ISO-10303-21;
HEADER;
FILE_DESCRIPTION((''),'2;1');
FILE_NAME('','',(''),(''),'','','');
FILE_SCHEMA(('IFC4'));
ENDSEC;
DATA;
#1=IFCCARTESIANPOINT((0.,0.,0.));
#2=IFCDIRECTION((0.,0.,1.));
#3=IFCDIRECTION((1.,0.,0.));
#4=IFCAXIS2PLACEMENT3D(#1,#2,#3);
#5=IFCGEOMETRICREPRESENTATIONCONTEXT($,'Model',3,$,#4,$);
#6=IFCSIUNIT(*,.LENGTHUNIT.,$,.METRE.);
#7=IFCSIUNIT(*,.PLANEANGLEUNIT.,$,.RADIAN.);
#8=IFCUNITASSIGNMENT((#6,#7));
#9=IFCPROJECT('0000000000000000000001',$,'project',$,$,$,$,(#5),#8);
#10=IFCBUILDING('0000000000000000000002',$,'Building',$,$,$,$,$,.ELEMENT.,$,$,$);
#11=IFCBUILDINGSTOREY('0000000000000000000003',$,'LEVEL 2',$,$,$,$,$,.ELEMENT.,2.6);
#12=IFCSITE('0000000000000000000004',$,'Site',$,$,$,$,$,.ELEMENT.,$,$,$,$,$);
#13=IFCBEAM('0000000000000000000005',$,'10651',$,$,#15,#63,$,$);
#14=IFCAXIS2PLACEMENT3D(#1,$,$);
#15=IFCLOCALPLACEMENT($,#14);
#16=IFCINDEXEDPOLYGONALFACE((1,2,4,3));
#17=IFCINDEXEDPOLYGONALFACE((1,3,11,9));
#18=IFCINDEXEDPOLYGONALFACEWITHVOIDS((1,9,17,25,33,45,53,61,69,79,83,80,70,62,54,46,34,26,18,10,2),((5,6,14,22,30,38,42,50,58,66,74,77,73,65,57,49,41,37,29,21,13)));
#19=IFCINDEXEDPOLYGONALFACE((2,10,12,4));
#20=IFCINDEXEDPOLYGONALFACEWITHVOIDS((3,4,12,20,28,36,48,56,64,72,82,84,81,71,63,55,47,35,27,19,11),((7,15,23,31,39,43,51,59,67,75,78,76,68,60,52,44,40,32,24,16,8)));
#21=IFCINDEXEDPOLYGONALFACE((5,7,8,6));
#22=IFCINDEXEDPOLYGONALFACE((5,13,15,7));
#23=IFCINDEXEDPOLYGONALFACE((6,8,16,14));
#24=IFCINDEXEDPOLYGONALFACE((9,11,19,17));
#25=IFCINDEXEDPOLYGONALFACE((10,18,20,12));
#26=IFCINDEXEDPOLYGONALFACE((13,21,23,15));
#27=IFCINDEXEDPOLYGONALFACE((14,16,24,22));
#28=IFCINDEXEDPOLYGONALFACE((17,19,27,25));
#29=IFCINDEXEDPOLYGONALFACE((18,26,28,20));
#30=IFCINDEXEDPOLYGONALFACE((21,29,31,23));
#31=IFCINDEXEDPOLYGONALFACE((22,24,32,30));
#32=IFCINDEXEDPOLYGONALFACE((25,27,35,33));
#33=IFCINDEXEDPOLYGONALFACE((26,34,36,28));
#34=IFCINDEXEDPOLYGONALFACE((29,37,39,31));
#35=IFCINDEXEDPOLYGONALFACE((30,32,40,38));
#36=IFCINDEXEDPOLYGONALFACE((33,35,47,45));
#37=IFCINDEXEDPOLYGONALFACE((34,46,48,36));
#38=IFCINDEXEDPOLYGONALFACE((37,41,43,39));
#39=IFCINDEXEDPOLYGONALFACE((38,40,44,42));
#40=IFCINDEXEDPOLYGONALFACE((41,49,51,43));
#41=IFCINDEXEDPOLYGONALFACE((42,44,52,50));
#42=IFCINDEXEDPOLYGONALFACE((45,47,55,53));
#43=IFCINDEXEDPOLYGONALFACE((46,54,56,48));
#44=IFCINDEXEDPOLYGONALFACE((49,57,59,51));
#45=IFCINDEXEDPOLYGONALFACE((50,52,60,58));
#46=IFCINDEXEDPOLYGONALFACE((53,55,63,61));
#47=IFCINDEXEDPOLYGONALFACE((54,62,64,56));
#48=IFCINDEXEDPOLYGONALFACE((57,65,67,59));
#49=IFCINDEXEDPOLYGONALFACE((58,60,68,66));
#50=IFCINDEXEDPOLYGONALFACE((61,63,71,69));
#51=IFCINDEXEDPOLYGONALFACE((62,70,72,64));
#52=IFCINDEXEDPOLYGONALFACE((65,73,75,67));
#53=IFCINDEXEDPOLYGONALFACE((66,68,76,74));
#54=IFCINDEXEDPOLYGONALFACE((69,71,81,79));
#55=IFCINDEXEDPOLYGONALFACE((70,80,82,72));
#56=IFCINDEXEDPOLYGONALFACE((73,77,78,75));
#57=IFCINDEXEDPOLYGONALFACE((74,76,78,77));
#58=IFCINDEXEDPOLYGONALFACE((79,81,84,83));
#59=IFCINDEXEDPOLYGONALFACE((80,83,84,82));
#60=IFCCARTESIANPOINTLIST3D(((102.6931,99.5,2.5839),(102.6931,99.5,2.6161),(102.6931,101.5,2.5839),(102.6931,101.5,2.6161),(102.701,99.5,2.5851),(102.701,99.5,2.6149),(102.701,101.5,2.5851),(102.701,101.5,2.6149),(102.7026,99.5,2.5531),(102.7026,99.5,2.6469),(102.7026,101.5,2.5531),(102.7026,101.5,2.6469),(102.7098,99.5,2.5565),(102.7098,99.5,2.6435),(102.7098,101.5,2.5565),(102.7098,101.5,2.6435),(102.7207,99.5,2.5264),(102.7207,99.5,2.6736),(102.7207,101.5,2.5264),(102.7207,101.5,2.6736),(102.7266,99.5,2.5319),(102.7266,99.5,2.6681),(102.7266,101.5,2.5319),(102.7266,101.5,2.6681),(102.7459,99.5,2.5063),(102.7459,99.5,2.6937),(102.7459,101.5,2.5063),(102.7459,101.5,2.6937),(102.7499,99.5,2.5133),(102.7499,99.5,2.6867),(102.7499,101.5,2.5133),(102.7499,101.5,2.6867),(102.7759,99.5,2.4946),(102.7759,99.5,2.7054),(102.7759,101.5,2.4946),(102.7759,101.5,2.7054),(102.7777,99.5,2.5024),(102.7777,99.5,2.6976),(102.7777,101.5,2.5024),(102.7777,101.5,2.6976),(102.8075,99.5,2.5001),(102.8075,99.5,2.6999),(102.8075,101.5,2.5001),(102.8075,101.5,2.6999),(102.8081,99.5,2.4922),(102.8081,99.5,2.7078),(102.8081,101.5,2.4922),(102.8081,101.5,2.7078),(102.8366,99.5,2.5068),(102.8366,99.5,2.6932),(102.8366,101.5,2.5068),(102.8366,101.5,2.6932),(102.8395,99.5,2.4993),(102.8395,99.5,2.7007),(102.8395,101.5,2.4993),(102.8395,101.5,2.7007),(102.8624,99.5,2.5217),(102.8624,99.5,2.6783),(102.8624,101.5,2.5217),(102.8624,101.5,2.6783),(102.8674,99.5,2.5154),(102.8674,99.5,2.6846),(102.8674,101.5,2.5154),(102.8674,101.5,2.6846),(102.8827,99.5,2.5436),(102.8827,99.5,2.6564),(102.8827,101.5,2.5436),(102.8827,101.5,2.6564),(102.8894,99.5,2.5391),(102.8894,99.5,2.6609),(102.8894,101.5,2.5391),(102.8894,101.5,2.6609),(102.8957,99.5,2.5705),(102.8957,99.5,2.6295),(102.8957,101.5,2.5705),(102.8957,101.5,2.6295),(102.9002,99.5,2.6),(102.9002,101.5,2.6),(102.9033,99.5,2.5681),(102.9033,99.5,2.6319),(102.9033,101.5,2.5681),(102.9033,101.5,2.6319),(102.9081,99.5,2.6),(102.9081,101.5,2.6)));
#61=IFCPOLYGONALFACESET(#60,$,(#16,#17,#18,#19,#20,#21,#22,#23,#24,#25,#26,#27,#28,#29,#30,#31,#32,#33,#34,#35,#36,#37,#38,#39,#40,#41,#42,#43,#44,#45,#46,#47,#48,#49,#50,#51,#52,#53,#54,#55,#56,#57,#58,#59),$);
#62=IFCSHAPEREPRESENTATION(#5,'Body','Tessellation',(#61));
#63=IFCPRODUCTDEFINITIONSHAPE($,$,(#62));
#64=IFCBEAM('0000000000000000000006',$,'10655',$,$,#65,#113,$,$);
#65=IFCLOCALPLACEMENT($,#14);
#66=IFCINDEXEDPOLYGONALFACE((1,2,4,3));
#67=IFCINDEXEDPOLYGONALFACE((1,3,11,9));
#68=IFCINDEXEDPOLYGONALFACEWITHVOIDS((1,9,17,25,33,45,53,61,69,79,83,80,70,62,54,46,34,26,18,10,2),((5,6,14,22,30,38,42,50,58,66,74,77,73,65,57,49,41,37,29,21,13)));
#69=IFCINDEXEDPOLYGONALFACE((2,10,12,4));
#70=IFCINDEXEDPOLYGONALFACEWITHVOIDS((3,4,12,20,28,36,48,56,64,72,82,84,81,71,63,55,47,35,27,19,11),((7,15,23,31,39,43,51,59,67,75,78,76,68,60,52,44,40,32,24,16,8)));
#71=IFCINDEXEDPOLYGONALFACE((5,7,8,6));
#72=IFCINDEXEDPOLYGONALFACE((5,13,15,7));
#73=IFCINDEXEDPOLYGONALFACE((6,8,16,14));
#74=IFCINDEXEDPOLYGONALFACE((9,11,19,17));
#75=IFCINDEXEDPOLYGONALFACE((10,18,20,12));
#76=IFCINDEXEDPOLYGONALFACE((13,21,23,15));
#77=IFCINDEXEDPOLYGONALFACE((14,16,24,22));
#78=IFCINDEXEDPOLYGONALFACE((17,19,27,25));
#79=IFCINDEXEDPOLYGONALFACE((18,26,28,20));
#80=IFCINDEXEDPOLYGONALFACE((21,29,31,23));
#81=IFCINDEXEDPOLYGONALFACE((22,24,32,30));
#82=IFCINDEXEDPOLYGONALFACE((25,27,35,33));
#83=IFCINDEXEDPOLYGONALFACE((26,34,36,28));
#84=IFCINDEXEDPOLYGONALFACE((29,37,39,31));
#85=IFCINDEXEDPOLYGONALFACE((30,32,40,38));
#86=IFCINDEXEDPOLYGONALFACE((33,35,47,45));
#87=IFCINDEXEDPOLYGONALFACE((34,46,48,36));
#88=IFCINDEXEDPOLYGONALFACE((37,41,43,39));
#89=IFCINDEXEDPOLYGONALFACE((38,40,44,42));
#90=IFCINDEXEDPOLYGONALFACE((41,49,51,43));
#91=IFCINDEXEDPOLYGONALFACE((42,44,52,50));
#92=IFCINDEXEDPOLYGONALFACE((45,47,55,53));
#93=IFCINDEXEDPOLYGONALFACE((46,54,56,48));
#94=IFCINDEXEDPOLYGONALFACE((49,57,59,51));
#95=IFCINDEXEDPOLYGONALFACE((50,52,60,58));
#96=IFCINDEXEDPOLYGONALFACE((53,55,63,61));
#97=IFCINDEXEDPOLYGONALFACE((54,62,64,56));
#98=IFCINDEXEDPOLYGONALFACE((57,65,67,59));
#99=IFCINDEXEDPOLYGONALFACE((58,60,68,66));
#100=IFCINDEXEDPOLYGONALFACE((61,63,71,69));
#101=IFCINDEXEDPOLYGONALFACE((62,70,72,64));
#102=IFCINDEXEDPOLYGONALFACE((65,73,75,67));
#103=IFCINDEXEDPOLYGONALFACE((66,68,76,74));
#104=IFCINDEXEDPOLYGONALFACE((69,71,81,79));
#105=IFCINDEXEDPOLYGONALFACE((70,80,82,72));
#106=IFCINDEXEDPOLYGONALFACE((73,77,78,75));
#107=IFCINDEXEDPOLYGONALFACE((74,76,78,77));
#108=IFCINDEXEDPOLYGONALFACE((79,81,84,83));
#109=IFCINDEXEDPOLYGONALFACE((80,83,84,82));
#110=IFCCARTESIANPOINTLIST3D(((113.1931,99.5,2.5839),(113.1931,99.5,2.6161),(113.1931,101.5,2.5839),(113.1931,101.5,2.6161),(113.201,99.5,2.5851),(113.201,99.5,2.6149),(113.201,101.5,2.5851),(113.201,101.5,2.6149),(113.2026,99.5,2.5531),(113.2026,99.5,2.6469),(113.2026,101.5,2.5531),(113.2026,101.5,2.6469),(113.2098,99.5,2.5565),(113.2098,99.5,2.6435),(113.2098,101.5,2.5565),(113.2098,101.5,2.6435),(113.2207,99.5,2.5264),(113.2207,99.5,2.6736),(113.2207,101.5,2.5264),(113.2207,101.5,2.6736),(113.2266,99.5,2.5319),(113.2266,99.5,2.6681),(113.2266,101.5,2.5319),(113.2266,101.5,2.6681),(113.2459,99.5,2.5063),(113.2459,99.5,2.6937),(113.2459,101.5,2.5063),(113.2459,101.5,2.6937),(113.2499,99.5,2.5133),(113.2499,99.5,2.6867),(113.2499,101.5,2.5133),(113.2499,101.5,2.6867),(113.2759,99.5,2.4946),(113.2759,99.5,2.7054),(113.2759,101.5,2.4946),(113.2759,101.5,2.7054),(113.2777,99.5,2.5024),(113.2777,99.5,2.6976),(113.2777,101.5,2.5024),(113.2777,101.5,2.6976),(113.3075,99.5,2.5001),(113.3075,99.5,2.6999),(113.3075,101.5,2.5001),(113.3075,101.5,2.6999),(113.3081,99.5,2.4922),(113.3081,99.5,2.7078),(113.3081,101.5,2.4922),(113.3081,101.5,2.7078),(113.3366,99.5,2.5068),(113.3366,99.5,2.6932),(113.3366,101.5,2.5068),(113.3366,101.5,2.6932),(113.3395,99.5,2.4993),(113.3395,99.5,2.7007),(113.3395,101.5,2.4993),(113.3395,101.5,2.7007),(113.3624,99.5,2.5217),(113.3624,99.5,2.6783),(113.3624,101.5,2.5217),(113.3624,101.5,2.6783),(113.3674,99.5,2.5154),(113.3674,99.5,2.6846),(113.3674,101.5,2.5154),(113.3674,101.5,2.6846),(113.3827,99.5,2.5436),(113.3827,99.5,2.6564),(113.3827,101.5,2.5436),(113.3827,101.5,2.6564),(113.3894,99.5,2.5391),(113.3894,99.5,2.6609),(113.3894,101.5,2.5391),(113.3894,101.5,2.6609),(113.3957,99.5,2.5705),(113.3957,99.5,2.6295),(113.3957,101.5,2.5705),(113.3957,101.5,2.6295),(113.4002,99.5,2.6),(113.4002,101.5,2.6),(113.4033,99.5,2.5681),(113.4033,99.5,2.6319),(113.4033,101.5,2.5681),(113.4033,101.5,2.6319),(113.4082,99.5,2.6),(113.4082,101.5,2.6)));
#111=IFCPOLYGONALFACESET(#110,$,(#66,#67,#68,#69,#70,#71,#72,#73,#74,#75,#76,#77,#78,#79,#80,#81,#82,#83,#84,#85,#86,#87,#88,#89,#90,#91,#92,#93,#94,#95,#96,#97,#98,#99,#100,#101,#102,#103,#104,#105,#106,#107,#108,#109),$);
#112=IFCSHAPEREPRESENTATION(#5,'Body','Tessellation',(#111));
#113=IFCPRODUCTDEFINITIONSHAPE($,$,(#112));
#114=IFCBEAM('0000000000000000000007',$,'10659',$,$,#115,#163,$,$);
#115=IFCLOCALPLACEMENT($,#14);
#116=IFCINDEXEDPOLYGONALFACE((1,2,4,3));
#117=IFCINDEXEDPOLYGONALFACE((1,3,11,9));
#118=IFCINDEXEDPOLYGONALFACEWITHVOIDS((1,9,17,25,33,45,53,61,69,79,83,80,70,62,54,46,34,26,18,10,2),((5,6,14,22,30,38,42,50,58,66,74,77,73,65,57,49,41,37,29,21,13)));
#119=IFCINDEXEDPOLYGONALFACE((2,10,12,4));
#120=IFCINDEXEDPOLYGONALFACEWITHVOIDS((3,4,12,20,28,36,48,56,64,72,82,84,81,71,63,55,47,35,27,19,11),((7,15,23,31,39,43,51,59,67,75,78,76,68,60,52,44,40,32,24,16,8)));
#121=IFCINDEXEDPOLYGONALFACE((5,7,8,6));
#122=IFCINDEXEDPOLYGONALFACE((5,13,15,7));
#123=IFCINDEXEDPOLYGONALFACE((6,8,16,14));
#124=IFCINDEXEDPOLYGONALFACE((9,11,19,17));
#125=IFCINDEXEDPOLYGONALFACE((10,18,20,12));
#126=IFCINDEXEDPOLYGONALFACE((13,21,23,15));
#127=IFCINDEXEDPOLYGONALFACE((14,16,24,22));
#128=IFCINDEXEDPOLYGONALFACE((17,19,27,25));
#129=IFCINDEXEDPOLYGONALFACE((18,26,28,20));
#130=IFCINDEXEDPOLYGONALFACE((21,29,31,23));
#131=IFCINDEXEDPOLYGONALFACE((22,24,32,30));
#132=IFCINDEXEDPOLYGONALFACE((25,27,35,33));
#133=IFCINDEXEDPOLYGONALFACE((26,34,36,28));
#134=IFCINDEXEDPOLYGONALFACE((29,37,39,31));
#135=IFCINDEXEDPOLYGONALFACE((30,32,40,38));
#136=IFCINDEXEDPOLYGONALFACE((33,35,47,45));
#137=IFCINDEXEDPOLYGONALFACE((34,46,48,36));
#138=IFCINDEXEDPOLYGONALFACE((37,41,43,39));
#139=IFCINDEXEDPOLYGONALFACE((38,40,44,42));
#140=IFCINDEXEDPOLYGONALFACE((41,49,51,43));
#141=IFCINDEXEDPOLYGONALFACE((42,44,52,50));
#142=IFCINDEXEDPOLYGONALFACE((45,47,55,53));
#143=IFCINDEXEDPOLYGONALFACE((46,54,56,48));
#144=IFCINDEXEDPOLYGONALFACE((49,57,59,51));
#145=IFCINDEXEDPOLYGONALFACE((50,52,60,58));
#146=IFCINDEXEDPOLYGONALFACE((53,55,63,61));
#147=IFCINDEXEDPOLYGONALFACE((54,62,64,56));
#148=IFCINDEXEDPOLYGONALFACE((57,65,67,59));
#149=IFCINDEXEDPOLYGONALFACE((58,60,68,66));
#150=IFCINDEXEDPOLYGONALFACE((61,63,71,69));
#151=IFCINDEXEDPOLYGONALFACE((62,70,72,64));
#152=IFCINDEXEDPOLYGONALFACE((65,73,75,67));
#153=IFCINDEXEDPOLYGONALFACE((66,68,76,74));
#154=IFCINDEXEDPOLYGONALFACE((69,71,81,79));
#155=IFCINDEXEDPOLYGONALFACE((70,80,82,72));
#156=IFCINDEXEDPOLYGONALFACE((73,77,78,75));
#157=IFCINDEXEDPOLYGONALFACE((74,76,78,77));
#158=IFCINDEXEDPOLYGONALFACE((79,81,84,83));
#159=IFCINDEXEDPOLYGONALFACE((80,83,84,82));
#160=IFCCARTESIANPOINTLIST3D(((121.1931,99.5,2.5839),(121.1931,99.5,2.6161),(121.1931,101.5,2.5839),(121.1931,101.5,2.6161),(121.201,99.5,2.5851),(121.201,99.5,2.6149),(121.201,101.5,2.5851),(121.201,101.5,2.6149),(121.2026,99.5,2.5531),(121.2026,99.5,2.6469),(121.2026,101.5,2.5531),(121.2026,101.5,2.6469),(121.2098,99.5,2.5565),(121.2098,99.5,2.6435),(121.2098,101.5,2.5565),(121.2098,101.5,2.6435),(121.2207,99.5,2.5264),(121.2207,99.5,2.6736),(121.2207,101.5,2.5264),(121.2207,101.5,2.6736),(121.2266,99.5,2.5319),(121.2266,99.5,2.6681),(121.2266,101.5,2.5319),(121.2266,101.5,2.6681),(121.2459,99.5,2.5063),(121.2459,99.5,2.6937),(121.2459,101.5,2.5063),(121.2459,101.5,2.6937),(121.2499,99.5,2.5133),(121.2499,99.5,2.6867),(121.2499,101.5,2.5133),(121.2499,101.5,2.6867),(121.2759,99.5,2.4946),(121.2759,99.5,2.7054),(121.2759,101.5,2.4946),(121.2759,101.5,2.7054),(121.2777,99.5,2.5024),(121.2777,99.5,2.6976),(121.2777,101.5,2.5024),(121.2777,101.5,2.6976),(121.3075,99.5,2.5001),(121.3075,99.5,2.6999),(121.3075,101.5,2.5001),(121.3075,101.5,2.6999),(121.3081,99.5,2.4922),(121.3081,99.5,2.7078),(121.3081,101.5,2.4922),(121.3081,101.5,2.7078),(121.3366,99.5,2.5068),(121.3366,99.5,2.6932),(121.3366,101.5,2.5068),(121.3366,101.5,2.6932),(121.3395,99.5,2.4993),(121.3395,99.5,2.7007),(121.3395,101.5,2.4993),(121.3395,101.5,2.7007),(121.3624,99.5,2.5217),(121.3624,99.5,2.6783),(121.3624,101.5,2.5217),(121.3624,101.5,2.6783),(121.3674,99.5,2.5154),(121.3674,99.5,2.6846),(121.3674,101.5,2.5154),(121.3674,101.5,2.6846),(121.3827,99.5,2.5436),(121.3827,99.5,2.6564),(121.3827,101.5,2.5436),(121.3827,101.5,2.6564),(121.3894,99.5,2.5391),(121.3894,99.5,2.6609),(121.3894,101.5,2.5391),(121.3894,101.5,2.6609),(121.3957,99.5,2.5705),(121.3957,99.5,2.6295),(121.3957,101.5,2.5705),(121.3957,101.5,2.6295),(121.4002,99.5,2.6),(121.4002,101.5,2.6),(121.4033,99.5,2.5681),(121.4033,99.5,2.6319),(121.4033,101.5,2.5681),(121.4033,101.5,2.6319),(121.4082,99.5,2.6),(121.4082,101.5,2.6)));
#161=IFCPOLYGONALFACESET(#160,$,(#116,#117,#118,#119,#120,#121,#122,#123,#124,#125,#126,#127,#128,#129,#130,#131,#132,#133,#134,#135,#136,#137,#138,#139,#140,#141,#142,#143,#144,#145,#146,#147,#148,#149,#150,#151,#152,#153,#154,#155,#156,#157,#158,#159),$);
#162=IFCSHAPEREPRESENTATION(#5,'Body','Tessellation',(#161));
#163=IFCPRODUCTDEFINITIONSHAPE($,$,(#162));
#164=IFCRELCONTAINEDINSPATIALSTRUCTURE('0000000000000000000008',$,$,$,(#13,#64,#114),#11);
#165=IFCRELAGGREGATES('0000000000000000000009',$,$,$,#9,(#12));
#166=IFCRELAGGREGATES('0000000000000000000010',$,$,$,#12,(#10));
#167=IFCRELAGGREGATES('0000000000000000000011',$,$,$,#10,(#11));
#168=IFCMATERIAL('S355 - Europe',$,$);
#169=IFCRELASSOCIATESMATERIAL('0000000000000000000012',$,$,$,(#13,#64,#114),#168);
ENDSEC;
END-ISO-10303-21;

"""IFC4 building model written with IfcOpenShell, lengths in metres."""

from ifc_helpers import new_model, si_unit, frame, origin_with_axes, origin_2d_with_axis, place, context, project, spatial, hollow_circle, extrude, material, material_profile, profile_set, profile_usage, element, save


model = new_model("IFC4")

# Units and contexts
model_context = context("Model", 3, world=origin_with_axes())
ifc_project = project(units=[si_unit("LENGTHUNIT", "METRE"), si_unit("PLANEANGLEUNIT", "RADIAN")], contexts=[model_context])

# Site, building, storey
site = spatial("IfcSite", under=ifc_project, Name="Site", CompositionType="ELEMENT")
building = spatial("IfcBuilding", under=site, Name="Building", CompositionType="ELEMENT")
storey = spatial("IfcBuildingStorey", under=building, Name="LEVEL 2", CompositionType="ELEMENT", Elevation=2.6)

# Shared definitions
ifc_material = material(Name="S355 - Europe")

# Beams
ifc_material_profile_1 = material_profile(ifc_material, hollow_circle(Radius=0.1081, WallThickness=0.008, at=origin_2d_with_axis()))
ifc_profile_set_1 = profile_set([ifc_material_profile_1])
ifc_profile_usage_1 = profile_usage(ifc_profile_set_1, cardinal=10)
beam_1_placement = place(None, frame((102.8, 101.5, 2.6), z_axis=(0.0, -1.0, 0.0), x_axis=(1.0, 0.0, 0.0)))
element("IfcBeam", 1, at=beam_1_placement, inside=storey, material=ifc_profile_usage_1, Name="10651", context=model_context, shape_type="SweptSolid", body=[
    extrude(hollow_circle(Radius=0.1081, WallThickness=0.008, at=origin_2d_with_axis()), origin_with_axes(), (0.0, 0.0, 1.0), 2.0),
])
ifc_material_profile_2 = material_profile(ifc_material, hollow_circle(Radius=0.1081, WallThickness=0.008, at=origin_2d_with_axis()))
ifc_profile_set_2 = profile_set([ifc_material_profile_2])
ifc_profile_usage_2 = profile_usage(ifc_profile_set_2, cardinal=10)
beam_2_placement = place(None, frame((113.3, 101.5, 2.6), z_axis=(0.0, -1.0, 0.0), x_axis=(1.0, 0.0, 0.0)))
element("IfcBeam", 2, at=beam_2_placement, inside=storey, material=ifc_profile_usage_2, Name="10655", context=model_context, shape_type="SweptSolid", body=[
    extrude(hollow_circle(Radius=0.1081, WallThickness=0.008, at=origin_2d_with_axis()), origin_with_axes(), (0.0, 0.0, 1.0), 2.0),
])
ifc_material_profile_3 = material_profile(ifc_material, hollow_circle(Radius=0.1081, WallThickness=0.008, at=origin_2d_with_axis()))
ifc_profile_set_3 = profile_set([ifc_material_profile_3])
ifc_profile_usage_3 = profile_usage(ifc_profile_set_3, cardinal=10)
beam_3_placement = place(None, frame((121.3, 101.5, 2.6), z_axis=(0.0, -1.0, 0.0), x_axis=(1.0, 0.0, 0.0)))
element("IfcBeam", 3, at=beam_3_placement, inside=storey, material=ifc_profile_usage_3, Name="10659", context=model_context, shape_type="SweptSolid", body=[
    extrude(hollow_circle(Radius=0.1081, WallThickness=0.008, at=origin_2d_with_axis()), origin_with_axes(), (0.0, 0.0, 1.0), 2.0),
])

save(model, "model.ifc")
